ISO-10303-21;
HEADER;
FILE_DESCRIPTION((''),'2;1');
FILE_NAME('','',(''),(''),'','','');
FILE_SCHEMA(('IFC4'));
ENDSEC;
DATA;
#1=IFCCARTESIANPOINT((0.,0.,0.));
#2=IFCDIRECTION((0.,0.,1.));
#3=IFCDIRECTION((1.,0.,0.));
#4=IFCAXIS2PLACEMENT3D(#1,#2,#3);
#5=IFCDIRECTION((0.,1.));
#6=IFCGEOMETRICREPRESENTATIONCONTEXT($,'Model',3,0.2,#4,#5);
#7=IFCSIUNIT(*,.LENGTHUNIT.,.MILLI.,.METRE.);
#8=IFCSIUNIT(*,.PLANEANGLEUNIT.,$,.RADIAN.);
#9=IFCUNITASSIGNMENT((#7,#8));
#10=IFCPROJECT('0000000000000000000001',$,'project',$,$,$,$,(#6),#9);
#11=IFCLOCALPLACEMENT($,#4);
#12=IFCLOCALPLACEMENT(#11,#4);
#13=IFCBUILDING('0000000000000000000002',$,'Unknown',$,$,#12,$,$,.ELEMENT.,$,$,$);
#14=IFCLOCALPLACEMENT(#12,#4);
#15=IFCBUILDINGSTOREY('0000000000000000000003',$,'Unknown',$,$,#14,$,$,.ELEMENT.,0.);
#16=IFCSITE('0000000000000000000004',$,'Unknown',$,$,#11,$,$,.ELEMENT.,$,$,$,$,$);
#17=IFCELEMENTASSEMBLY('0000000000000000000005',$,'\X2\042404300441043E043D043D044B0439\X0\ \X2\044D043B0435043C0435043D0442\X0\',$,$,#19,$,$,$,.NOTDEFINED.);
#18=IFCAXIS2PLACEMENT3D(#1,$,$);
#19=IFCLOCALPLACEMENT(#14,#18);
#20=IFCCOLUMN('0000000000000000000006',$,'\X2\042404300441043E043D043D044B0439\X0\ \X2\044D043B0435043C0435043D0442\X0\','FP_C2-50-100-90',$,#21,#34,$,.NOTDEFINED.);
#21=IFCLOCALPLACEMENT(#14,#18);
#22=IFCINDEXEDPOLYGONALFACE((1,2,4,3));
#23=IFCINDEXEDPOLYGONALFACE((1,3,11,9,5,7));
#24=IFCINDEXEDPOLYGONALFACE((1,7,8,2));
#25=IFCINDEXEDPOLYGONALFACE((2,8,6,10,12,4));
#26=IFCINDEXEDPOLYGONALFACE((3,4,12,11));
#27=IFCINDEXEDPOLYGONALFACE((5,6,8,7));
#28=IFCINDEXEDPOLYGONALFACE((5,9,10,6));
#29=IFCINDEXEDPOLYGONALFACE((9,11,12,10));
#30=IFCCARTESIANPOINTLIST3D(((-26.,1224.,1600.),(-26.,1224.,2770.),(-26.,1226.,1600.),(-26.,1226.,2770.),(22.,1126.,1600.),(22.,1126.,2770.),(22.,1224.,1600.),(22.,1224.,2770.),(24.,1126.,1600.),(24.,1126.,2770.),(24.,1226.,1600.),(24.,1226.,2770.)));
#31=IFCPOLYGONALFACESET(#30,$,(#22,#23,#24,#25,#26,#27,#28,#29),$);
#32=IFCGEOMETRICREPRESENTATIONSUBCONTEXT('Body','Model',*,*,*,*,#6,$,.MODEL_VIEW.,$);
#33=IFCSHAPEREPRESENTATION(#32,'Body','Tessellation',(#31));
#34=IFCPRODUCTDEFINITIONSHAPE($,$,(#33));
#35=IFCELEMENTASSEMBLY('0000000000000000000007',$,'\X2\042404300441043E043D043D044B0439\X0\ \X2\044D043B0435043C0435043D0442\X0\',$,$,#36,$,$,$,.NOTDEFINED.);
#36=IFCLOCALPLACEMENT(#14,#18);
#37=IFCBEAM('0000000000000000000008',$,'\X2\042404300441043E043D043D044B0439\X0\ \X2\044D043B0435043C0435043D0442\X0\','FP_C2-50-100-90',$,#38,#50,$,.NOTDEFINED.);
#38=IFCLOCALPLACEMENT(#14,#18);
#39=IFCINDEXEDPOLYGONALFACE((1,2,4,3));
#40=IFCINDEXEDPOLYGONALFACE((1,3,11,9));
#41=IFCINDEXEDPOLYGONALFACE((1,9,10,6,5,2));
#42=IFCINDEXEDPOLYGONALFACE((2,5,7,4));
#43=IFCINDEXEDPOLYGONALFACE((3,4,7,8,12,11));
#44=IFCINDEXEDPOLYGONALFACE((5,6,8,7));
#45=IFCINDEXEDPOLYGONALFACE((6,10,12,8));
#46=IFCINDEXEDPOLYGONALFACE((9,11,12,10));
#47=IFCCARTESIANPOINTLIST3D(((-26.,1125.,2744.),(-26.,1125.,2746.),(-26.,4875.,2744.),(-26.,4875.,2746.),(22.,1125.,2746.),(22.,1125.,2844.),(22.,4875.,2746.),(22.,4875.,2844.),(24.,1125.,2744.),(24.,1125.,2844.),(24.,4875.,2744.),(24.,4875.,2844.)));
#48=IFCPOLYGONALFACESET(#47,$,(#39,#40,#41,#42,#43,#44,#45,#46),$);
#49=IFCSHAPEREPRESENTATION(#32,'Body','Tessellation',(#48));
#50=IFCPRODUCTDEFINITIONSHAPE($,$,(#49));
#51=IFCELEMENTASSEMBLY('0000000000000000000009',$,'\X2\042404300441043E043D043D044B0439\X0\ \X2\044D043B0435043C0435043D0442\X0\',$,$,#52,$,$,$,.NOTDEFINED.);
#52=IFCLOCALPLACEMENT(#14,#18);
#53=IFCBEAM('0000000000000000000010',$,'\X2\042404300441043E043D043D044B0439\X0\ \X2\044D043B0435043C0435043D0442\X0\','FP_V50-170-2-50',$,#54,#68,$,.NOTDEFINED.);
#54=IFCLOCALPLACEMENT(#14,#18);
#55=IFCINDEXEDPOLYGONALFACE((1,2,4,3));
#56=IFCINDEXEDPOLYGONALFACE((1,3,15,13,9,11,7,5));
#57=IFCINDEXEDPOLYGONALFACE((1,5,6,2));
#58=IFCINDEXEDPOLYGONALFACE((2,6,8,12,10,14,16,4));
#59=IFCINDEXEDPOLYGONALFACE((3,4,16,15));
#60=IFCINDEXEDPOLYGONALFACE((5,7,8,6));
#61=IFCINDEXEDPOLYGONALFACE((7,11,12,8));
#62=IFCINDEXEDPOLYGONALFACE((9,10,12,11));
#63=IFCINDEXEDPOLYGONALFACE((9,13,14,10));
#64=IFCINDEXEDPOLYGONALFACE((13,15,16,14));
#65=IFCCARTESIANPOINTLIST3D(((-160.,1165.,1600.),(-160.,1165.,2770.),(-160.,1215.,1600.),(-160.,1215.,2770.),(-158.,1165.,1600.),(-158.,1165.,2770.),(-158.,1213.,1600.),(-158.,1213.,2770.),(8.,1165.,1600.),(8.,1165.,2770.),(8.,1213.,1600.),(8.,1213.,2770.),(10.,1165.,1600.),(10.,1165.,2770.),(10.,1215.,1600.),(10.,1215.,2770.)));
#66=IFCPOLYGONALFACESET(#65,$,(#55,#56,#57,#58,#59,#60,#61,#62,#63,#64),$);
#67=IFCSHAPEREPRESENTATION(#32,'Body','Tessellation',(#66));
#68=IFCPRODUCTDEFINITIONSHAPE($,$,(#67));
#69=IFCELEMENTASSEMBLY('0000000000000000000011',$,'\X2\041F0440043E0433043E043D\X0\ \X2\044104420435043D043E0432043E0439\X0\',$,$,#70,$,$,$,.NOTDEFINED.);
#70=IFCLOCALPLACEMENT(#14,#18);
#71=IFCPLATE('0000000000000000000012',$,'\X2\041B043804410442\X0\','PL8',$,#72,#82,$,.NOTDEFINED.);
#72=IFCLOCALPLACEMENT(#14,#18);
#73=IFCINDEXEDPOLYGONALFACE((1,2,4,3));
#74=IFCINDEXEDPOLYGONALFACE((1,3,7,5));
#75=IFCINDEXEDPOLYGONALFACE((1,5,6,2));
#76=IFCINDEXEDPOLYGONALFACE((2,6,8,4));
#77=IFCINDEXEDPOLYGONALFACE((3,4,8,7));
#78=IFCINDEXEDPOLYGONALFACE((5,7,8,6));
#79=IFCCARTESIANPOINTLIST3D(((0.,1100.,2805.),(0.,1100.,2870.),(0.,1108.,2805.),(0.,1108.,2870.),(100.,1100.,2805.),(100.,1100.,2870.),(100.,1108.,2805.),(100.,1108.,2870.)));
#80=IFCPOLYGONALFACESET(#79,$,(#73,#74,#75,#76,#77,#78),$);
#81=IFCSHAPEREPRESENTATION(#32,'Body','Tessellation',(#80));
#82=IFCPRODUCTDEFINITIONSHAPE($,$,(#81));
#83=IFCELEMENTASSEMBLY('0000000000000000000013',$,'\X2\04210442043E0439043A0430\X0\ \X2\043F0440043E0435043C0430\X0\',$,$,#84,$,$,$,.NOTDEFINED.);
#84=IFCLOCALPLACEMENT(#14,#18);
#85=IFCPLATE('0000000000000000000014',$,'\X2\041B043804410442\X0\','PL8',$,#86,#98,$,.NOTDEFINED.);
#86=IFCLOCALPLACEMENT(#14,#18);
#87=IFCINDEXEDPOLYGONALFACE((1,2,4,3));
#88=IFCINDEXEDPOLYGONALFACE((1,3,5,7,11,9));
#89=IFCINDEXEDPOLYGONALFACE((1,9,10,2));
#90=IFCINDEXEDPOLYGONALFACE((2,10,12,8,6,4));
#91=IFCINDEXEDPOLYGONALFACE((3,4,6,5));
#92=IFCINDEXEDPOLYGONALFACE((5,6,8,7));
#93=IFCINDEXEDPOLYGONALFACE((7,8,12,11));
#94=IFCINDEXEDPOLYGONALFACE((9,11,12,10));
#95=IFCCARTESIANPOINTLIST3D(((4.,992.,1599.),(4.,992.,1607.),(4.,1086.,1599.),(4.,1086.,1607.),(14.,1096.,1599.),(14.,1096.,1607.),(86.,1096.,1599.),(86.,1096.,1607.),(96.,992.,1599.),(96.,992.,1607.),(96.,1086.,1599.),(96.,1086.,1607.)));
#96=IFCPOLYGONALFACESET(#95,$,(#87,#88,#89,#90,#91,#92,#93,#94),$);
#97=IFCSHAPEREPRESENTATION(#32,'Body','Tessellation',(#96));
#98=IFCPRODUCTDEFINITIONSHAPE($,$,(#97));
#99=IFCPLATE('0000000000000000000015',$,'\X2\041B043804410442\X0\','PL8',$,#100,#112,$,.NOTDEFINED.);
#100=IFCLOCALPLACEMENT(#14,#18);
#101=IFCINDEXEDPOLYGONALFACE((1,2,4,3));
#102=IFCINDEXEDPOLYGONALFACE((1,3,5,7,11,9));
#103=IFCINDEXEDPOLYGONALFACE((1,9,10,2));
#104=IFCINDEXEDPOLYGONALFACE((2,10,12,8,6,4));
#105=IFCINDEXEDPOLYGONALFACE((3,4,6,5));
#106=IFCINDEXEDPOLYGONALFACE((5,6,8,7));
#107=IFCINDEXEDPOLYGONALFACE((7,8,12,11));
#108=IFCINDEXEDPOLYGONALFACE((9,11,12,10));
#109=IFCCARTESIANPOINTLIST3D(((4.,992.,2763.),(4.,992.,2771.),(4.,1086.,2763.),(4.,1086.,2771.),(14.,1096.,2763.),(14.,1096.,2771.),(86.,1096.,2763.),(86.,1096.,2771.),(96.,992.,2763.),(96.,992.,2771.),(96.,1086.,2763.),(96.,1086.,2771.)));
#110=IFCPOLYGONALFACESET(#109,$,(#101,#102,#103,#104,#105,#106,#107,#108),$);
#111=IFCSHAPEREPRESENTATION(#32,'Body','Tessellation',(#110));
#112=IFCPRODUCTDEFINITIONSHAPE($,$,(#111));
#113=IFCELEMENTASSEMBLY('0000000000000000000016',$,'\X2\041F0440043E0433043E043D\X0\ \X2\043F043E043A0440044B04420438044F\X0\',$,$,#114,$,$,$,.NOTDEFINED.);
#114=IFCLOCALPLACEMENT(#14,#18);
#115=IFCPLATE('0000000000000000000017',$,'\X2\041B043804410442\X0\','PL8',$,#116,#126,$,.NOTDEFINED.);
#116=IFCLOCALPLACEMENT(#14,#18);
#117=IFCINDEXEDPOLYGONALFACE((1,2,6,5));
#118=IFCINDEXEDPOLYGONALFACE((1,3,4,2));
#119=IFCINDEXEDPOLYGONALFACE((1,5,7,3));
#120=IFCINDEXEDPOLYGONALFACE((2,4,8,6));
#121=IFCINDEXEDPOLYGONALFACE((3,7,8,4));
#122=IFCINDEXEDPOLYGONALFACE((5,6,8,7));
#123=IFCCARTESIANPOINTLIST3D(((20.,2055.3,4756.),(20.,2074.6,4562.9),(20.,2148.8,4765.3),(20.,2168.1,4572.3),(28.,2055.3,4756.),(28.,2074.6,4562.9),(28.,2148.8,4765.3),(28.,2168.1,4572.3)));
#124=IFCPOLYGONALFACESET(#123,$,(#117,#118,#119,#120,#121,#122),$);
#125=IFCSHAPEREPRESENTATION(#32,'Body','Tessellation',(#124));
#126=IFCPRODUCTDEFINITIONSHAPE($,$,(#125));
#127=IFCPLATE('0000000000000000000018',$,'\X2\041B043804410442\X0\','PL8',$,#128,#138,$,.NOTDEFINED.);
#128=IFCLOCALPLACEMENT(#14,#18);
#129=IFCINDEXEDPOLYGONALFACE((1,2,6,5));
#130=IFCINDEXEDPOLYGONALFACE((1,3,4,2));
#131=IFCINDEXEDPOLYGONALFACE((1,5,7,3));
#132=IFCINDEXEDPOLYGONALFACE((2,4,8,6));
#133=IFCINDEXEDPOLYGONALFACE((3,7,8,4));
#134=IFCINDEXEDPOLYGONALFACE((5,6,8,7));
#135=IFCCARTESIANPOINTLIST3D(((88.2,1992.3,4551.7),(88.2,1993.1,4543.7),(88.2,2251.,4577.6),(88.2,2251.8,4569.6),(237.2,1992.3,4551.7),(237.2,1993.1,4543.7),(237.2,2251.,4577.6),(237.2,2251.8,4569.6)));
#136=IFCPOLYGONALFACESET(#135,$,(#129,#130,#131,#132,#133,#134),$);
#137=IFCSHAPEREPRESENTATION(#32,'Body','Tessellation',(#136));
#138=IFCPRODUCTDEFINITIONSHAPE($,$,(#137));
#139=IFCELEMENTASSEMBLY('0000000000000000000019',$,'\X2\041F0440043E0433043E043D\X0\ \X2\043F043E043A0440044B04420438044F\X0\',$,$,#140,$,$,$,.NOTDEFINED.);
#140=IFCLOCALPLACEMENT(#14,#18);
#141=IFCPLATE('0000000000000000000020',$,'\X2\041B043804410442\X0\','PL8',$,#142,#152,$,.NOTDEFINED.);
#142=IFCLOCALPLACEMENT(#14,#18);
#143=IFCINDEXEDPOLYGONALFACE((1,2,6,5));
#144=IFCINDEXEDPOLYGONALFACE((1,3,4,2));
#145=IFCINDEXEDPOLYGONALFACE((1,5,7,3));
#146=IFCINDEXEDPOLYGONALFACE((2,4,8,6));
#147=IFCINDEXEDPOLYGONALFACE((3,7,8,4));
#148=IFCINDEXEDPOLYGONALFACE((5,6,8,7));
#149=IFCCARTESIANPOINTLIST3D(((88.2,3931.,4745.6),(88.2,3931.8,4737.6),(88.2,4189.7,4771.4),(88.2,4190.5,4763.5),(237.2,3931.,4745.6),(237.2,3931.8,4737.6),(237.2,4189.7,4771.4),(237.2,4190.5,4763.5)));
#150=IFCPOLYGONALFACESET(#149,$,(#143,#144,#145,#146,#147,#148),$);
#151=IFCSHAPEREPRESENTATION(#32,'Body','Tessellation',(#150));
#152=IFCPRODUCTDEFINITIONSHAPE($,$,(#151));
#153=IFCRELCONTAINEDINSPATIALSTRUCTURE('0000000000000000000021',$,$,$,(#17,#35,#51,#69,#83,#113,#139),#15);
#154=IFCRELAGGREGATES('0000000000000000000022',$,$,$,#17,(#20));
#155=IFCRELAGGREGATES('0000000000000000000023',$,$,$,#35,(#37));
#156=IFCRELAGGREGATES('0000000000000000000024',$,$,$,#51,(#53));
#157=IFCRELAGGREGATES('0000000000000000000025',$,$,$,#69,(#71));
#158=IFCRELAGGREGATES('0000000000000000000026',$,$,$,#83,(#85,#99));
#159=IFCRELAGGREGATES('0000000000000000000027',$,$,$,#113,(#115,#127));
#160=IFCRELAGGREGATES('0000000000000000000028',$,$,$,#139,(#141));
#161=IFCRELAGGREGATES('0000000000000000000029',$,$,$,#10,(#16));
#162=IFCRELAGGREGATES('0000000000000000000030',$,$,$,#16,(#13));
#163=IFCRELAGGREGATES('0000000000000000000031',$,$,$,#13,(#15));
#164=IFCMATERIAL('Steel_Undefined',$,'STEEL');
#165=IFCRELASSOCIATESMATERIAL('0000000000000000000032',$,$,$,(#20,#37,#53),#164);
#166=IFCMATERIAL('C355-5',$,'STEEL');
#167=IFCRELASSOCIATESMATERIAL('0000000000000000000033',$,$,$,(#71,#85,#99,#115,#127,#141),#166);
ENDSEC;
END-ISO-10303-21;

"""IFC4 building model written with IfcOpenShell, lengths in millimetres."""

from ifc_helpers import new_model, si_unit, direction, frame, origin_with_axes, place, context, subcontext, project, spatial, line, indexed_curve, outline, extrude, material, element, aggregate, save


model = new_model("IFC4")

# Units and contexts
model_context = context("Model", 3, precision=0.2, world=origin_with_axes(), true_north=direction((0.0, 1.0)))
body_context = subcontext(model_context, "Body", "Model", "MODEL_VIEW")
ifc_project = project(units=[si_unit("LENGTHUNIT", "METRE", prefix="MILLI"), si_unit("PLANEANGLEUNIT", "RADIAN")], contexts=[model_context])

# Site, building, storey
site_placement = place(None, origin_with_axes())
site = spatial("IfcSite", under=ifc_project, at=site_placement, Name="Unknown", CompositionType="ELEMENT")
building_placement = place(site_placement, origin_with_axes())
building = spatial("IfcBuilding", under=site, at=building_placement, Name="Unknown", CompositionType="ELEMENT")
storey_placement = place(building_placement, origin_with_axes())
storey = spatial("IfcBuildingStorey", under=building, at=storey_placement, Name="Unknown", CompositionType="ELEMENT", Elevation=0.0)

# Element assembly, column
assembly_1_placement = place(storey_placement, frame((-1.0, 1225.0, 1600.0), z_axis=(1.0, 0.0, 0.0), x_axis=(0.0, 0.0, 1.0)))
assembly_1 = element("IfcElementAssembly", 1, at=assembly_1_placement, inside=storey, Name="Фасонный элемент", PredefinedType="NOTDEFINED")
ifc_material_1 = material(Name="Steel_Undefined", Category="STEEL")
column_placement = place(assembly_1_placement, origin_with_axes())
column = element("IfcColumn", 2, at=column_placement, material=ifc_material_1, Name="Фасонный элемент", Description="FP_C2-50-100-90", PredefinedType="NOTDEFINED", context=body_context, shape_type="SolidModel", body=[
    extrude(outline(indexed_curve([(-25.0, -1.0), (25.0, -1.0), (25.0, 99.0), (23.0, 99.0), (23.0, 1.0), (-25.0, 1.0)], segments=[line(1, 2, 3, 4, 5, 6, 1)])), frame((0.0, 0.0, 0.0), z_axis=(-1.0, 0.0, 0.0), x_axis=(0.0, 0.0, 1.0)), (0.0, 0.0, -1.0), 1170.0),
])
aggregate(assembly_1, [column])

# Element assemblies, beams
assembly_2_placement = place(storey_placement, frame((-1.0, 1125.0, 2745.0), z_axis=(1.0, 0.0, 0.0), x_axis=(0.0, 1.0, 0.0)))
assembly_2 = element("IfcElementAssembly", 3, at=assembly_2_placement, inside=storey, Name="Фасонный элемент", PredefinedType="NOTDEFINED")
beam_1_placement = place(assembly_2_placement, origin_with_axes())
beam_1 = element("IfcBeam", 4, at=beam_1_placement, material=ifc_material_1, Name="Фасонный элемент", Description="FP_C2-50-100-90", PredefinedType="NOTDEFINED", context=body_context, shape_type="SolidModel", body=[
    extrude(outline(indexed_curve([(-25.0, -1.0), (25.0, -1.0), (25.0, 99.0), (23.0, 99.0), (23.0, 1.0), (-25.0, 1.0)], segments=[line(1, 2, 3, 4, 5, 6, 1)])), frame((0.0, 0.0, 0.0), z_axis=(-1.0, 0.0, 0.0), x_axis=(0.0, 0.0, 1.0)), (0.0, 0.0, -1.0), 3750.0),
])
aggregate(assembly_2, [beam_1])
assembly_3_placement = place(storey_placement, frame((-75.0, 1190.0, 2770.0), z_axis=(1.0, 0.0, 0.0), x_axis=(0.0, 0.0, -1.0)))
assembly_3 = element("IfcElementAssembly", 5, at=assembly_3_placement, inside=storey, Name="Фасонный элемент", PredefinedType="NOTDEFINED")
beam_2_placement = place(assembly_3_placement, origin_with_axes())
beam_2 = element("IfcBeam", 6, at=beam_2_placement, material=ifc_material_1, Name="Фасонный элемент", Description="FP_V50-170-2-50", PredefinedType="NOTDEFINED", context=body_context, shape_type="SolidModel", body=[
    extrude(outline(indexed_curve([(-85.0, -25.0), (-83.0, -25.0), (-83.0, 23.0), (83.0, 23.0), (83.0, -25.0), (85.0, -25.0), (85.0, 25.0), (-85.0, 25.0)], segments=[line(1, 2, 3, 4, 5, 6, 7, 8, 1)])), frame((0.0, 0.0, 0.0), z_axis=(-1.0, 0.0, 0.0), x_axis=(0.0, 0.0, 1.0)), (0.0, 0.0, -1.0), 1170.0),
])
aggregate(assembly_3, [beam_2])

# Shared definitions
ifc_material_2 = material(Name="C355-5", Category="STEEL")

# Element assembly, plate
assembly_4_placement = place(storey_placement, frame((50.0, 6000.0, 2920.0), z_axis=(0.0, 0.0, -1.0), x_axis=(0.0, -1.0, 0.0)))
assembly_4 = element("IfcElementAssembly", 7, at=assembly_4_placement, inside=storey, Name="Прогон стеновой", PredefinedType="NOTDEFINED")
plate_1_placement = place(assembly_4_placement, frame((4896.0, -50.0, 50.0), z_axis=(-1.0, 0.0, 0.0), x_axis=(0.0, 0.0, 1.0)))
plate_1 = element("IfcPlate", 8, at=plate_1_placement, material=ifc_material_2, Name="Лист", Description="PL8", PredefinedType="NOTDEFINED", context=body_context, shape_type="SolidModel", body=[
    extrude(outline(indexed_curve([(0.0, 0.0), (65.0, 0.0), (65.0, 100.0), (0.0, 100.0)], segments=[line(1, 2, 3, 4, 1)])), frame((0.0, 0.0, 4.0), z_axis=(0.0, 0.0, 1.0), x_axis=(1.0, 0.0, 0.0)), (0.0, 0.0, -1.0), 8.0),
])
aggregate(assembly_4, [plate_1])

# Element assemblies, plates
assembly_5_placement = place(storey_placement, frame((50.0, 1050.0, 1500.0), z_axis=(0.0, -1.0, 0.0), x_axis=(0.0, 0.0, 1.0)))
assembly_5 = element("IfcElementAssembly", 9, at=assembly_5_placement, inside=storey, Name="Стойка проема", PredefinedType="NOTDEFINED")
plate_2_placement = place(assembly_5_placement, frame((103.0, 46.0, -46.0), z_axis=(-1.0, 0.0, 0.0), x_axis=(0.0, -1.0, 0.0)))
plate_2 = element("IfcPlate", 10, at=plate_2_placement, material=ifc_material_2, Name="Лист", Description="PL8", PredefinedType="NOTDEFINED", context=body_context, shape_type="SolidModel", body=[
    extrude(outline(indexed_curve([(0.0, 10.0), (10.0, 0.0), (82.0, 0.0), (92.0, 10.0), (92.0, 104.0), (0.0, 104.0)], segments=[line(1, 2, 3, 4, 5, 6, 1)])), frame((0.0, 0.0, 4.0), z_axis=(0.0, 0.0, 1.0), x_axis=(1.0, 0.0, 0.0)), (0.0, 0.0, -1.0), 8.0),
])
plate_3_placement = place(assembly_5_placement, frame((1267.0, -46.0, -46.0), z_axis=(1.0, 0.0, 0.0), x_axis=(0.0, 1.0, 0.0)))
plate_3 = element("IfcPlate", 11, at=plate_3_placement, material=ifc_material_2, Name="Лист", Description="PL8", PredefinedType="NOTDEFINED", context=body_context, shape_type="SolidModel", body=[
    extrude(outline(indexed_curve([(0.0, 10.0), (10.0, 0.0), (82.0, 0.0), (92.0, 10.0), (92.0, 104.0), (0.0, 104.0)], segments=[line(1, 2, 3, 4, 5, 6, 1)])), frame((0.0, 0.0, 4.0), z_axis=(0.0, 0.0, 1.0), x_axis=(1.0, 0.0, 0.0)), (0.0, 0.0, -1.0), 8.0),
])
aggregate(assembly_5, [plate_2, plate_3])
assembly_6_placement = place(storey_placement, frame((0.0, 2111.7, 4664.1), z_axis=(0.0, 0.995037, 0.099504), x_axis=(1.0, 0.0, 0.0)))
assembly_6 = element("IfcElementAssembly", 12, at=assembly_6_placement, inside=storey, Name="Прогон покрытия", PredefinedType="NOTDEFINED")
plate_4_placement = place(assembly_6_placement, frame((24.0, 97.0, 47.0), z_axis=(-1.0, 0.0, 0.0), x_axis=(0.0, 0.0, -1.0)))
plate_4 = element("IfcPlate", 13, at=plate_4_placement, material=ifc_material_2, Name="Лист", Description="PL8", PredefinedType="NOTDEFINED", context=body_context, shape_type="SolidModel", body=[
    extrude(outline(indexed_curve([(0.0, 0.0), (94.0, 0.0), (94.0, 194.0), (0.0, 194.0)], segments=[line(1, 2, 3, 4, 1)])), frame((0.0, 0.0, 4.0), z_axis=(0.0, 0.0, 1.0), x_axis=(1.0, 0.0, 0.0)), (0.0, 0.0, -1.0), 8.0),
])
plate_5_placement = place(assembly_6_placement, frame((88.2, 104.0, -130.0), z_axis=(0.0, 1.0, 0.0), x_axis=(0.0, 0.0, 1.0)))
plate_5 = element("IfcPlate", 14, at=plate_5_placement, material=ifc_material_2, Name="Лист", Description="PL8", PredefinedType="NOTDEFINED", context=body_context, shape_type="SolidModel", body=[
    extrude(outline(indexed_curve([(0.0, 0.0), (260.0, 0.0), (260.0, 149.0), (0.0, 149.0)], segments=[line(1, 2, 3, 4, 1)])), frame((0.0, 0.0, 4.0), z_axis=(0.0, 0.0, 1.0), x_axis=(1.0, 0.0, 0.0)), (0.0, 0.0, -1.0), 8.0),
])
aggregate(assembly_6, [plate_4, plate_5])

# Element assembly, plate
assembly_7_placement = place(storey_placement, frame((0.0, 4050.4, 4858.0), z_axis=(0.0, 0.995037, 0.099504), x_axis=(1.0, 0.0, 0.0)))
assembly_7 = element("IfcElementAssembly", 15, at=assembly_7_placement, inside=storey, Name="Прогон покрытия", PredefinedType="NOTDEFINED")
plate_6_placement = place(assembly_7_placement, frame((88.2, 104.0, -130.0), z_axis=(0.0, 1.0, 0.0), x_axis=(0.0, 0.0, 1.0)))
plate_6 = element("IfcPlate", 16, at=plate_6_placement, material=ifc_material_2, Name="Лист", Description="PL8", PredefinedType="NOTDEFINED", context=body_context, shape_type="SolidModel", body=[
    extrude(outline(indexed_curve([(0.0, 0.0), (260.0, 0.0), (260.0, 149.0), (0.0, 149.0)], segments=[line(1, 2, 3, 4, 1)])), frame((0.0, 0.0, 4.0), z_axis=(0.0, 0.0, 1.0), x_axis=(1.0, 0.0, 0.0)), (0.0, 0.0, -1.0), 8.0),
])
aggregate(assembly_7, [plate_6])

save(model, "model.ifc")
